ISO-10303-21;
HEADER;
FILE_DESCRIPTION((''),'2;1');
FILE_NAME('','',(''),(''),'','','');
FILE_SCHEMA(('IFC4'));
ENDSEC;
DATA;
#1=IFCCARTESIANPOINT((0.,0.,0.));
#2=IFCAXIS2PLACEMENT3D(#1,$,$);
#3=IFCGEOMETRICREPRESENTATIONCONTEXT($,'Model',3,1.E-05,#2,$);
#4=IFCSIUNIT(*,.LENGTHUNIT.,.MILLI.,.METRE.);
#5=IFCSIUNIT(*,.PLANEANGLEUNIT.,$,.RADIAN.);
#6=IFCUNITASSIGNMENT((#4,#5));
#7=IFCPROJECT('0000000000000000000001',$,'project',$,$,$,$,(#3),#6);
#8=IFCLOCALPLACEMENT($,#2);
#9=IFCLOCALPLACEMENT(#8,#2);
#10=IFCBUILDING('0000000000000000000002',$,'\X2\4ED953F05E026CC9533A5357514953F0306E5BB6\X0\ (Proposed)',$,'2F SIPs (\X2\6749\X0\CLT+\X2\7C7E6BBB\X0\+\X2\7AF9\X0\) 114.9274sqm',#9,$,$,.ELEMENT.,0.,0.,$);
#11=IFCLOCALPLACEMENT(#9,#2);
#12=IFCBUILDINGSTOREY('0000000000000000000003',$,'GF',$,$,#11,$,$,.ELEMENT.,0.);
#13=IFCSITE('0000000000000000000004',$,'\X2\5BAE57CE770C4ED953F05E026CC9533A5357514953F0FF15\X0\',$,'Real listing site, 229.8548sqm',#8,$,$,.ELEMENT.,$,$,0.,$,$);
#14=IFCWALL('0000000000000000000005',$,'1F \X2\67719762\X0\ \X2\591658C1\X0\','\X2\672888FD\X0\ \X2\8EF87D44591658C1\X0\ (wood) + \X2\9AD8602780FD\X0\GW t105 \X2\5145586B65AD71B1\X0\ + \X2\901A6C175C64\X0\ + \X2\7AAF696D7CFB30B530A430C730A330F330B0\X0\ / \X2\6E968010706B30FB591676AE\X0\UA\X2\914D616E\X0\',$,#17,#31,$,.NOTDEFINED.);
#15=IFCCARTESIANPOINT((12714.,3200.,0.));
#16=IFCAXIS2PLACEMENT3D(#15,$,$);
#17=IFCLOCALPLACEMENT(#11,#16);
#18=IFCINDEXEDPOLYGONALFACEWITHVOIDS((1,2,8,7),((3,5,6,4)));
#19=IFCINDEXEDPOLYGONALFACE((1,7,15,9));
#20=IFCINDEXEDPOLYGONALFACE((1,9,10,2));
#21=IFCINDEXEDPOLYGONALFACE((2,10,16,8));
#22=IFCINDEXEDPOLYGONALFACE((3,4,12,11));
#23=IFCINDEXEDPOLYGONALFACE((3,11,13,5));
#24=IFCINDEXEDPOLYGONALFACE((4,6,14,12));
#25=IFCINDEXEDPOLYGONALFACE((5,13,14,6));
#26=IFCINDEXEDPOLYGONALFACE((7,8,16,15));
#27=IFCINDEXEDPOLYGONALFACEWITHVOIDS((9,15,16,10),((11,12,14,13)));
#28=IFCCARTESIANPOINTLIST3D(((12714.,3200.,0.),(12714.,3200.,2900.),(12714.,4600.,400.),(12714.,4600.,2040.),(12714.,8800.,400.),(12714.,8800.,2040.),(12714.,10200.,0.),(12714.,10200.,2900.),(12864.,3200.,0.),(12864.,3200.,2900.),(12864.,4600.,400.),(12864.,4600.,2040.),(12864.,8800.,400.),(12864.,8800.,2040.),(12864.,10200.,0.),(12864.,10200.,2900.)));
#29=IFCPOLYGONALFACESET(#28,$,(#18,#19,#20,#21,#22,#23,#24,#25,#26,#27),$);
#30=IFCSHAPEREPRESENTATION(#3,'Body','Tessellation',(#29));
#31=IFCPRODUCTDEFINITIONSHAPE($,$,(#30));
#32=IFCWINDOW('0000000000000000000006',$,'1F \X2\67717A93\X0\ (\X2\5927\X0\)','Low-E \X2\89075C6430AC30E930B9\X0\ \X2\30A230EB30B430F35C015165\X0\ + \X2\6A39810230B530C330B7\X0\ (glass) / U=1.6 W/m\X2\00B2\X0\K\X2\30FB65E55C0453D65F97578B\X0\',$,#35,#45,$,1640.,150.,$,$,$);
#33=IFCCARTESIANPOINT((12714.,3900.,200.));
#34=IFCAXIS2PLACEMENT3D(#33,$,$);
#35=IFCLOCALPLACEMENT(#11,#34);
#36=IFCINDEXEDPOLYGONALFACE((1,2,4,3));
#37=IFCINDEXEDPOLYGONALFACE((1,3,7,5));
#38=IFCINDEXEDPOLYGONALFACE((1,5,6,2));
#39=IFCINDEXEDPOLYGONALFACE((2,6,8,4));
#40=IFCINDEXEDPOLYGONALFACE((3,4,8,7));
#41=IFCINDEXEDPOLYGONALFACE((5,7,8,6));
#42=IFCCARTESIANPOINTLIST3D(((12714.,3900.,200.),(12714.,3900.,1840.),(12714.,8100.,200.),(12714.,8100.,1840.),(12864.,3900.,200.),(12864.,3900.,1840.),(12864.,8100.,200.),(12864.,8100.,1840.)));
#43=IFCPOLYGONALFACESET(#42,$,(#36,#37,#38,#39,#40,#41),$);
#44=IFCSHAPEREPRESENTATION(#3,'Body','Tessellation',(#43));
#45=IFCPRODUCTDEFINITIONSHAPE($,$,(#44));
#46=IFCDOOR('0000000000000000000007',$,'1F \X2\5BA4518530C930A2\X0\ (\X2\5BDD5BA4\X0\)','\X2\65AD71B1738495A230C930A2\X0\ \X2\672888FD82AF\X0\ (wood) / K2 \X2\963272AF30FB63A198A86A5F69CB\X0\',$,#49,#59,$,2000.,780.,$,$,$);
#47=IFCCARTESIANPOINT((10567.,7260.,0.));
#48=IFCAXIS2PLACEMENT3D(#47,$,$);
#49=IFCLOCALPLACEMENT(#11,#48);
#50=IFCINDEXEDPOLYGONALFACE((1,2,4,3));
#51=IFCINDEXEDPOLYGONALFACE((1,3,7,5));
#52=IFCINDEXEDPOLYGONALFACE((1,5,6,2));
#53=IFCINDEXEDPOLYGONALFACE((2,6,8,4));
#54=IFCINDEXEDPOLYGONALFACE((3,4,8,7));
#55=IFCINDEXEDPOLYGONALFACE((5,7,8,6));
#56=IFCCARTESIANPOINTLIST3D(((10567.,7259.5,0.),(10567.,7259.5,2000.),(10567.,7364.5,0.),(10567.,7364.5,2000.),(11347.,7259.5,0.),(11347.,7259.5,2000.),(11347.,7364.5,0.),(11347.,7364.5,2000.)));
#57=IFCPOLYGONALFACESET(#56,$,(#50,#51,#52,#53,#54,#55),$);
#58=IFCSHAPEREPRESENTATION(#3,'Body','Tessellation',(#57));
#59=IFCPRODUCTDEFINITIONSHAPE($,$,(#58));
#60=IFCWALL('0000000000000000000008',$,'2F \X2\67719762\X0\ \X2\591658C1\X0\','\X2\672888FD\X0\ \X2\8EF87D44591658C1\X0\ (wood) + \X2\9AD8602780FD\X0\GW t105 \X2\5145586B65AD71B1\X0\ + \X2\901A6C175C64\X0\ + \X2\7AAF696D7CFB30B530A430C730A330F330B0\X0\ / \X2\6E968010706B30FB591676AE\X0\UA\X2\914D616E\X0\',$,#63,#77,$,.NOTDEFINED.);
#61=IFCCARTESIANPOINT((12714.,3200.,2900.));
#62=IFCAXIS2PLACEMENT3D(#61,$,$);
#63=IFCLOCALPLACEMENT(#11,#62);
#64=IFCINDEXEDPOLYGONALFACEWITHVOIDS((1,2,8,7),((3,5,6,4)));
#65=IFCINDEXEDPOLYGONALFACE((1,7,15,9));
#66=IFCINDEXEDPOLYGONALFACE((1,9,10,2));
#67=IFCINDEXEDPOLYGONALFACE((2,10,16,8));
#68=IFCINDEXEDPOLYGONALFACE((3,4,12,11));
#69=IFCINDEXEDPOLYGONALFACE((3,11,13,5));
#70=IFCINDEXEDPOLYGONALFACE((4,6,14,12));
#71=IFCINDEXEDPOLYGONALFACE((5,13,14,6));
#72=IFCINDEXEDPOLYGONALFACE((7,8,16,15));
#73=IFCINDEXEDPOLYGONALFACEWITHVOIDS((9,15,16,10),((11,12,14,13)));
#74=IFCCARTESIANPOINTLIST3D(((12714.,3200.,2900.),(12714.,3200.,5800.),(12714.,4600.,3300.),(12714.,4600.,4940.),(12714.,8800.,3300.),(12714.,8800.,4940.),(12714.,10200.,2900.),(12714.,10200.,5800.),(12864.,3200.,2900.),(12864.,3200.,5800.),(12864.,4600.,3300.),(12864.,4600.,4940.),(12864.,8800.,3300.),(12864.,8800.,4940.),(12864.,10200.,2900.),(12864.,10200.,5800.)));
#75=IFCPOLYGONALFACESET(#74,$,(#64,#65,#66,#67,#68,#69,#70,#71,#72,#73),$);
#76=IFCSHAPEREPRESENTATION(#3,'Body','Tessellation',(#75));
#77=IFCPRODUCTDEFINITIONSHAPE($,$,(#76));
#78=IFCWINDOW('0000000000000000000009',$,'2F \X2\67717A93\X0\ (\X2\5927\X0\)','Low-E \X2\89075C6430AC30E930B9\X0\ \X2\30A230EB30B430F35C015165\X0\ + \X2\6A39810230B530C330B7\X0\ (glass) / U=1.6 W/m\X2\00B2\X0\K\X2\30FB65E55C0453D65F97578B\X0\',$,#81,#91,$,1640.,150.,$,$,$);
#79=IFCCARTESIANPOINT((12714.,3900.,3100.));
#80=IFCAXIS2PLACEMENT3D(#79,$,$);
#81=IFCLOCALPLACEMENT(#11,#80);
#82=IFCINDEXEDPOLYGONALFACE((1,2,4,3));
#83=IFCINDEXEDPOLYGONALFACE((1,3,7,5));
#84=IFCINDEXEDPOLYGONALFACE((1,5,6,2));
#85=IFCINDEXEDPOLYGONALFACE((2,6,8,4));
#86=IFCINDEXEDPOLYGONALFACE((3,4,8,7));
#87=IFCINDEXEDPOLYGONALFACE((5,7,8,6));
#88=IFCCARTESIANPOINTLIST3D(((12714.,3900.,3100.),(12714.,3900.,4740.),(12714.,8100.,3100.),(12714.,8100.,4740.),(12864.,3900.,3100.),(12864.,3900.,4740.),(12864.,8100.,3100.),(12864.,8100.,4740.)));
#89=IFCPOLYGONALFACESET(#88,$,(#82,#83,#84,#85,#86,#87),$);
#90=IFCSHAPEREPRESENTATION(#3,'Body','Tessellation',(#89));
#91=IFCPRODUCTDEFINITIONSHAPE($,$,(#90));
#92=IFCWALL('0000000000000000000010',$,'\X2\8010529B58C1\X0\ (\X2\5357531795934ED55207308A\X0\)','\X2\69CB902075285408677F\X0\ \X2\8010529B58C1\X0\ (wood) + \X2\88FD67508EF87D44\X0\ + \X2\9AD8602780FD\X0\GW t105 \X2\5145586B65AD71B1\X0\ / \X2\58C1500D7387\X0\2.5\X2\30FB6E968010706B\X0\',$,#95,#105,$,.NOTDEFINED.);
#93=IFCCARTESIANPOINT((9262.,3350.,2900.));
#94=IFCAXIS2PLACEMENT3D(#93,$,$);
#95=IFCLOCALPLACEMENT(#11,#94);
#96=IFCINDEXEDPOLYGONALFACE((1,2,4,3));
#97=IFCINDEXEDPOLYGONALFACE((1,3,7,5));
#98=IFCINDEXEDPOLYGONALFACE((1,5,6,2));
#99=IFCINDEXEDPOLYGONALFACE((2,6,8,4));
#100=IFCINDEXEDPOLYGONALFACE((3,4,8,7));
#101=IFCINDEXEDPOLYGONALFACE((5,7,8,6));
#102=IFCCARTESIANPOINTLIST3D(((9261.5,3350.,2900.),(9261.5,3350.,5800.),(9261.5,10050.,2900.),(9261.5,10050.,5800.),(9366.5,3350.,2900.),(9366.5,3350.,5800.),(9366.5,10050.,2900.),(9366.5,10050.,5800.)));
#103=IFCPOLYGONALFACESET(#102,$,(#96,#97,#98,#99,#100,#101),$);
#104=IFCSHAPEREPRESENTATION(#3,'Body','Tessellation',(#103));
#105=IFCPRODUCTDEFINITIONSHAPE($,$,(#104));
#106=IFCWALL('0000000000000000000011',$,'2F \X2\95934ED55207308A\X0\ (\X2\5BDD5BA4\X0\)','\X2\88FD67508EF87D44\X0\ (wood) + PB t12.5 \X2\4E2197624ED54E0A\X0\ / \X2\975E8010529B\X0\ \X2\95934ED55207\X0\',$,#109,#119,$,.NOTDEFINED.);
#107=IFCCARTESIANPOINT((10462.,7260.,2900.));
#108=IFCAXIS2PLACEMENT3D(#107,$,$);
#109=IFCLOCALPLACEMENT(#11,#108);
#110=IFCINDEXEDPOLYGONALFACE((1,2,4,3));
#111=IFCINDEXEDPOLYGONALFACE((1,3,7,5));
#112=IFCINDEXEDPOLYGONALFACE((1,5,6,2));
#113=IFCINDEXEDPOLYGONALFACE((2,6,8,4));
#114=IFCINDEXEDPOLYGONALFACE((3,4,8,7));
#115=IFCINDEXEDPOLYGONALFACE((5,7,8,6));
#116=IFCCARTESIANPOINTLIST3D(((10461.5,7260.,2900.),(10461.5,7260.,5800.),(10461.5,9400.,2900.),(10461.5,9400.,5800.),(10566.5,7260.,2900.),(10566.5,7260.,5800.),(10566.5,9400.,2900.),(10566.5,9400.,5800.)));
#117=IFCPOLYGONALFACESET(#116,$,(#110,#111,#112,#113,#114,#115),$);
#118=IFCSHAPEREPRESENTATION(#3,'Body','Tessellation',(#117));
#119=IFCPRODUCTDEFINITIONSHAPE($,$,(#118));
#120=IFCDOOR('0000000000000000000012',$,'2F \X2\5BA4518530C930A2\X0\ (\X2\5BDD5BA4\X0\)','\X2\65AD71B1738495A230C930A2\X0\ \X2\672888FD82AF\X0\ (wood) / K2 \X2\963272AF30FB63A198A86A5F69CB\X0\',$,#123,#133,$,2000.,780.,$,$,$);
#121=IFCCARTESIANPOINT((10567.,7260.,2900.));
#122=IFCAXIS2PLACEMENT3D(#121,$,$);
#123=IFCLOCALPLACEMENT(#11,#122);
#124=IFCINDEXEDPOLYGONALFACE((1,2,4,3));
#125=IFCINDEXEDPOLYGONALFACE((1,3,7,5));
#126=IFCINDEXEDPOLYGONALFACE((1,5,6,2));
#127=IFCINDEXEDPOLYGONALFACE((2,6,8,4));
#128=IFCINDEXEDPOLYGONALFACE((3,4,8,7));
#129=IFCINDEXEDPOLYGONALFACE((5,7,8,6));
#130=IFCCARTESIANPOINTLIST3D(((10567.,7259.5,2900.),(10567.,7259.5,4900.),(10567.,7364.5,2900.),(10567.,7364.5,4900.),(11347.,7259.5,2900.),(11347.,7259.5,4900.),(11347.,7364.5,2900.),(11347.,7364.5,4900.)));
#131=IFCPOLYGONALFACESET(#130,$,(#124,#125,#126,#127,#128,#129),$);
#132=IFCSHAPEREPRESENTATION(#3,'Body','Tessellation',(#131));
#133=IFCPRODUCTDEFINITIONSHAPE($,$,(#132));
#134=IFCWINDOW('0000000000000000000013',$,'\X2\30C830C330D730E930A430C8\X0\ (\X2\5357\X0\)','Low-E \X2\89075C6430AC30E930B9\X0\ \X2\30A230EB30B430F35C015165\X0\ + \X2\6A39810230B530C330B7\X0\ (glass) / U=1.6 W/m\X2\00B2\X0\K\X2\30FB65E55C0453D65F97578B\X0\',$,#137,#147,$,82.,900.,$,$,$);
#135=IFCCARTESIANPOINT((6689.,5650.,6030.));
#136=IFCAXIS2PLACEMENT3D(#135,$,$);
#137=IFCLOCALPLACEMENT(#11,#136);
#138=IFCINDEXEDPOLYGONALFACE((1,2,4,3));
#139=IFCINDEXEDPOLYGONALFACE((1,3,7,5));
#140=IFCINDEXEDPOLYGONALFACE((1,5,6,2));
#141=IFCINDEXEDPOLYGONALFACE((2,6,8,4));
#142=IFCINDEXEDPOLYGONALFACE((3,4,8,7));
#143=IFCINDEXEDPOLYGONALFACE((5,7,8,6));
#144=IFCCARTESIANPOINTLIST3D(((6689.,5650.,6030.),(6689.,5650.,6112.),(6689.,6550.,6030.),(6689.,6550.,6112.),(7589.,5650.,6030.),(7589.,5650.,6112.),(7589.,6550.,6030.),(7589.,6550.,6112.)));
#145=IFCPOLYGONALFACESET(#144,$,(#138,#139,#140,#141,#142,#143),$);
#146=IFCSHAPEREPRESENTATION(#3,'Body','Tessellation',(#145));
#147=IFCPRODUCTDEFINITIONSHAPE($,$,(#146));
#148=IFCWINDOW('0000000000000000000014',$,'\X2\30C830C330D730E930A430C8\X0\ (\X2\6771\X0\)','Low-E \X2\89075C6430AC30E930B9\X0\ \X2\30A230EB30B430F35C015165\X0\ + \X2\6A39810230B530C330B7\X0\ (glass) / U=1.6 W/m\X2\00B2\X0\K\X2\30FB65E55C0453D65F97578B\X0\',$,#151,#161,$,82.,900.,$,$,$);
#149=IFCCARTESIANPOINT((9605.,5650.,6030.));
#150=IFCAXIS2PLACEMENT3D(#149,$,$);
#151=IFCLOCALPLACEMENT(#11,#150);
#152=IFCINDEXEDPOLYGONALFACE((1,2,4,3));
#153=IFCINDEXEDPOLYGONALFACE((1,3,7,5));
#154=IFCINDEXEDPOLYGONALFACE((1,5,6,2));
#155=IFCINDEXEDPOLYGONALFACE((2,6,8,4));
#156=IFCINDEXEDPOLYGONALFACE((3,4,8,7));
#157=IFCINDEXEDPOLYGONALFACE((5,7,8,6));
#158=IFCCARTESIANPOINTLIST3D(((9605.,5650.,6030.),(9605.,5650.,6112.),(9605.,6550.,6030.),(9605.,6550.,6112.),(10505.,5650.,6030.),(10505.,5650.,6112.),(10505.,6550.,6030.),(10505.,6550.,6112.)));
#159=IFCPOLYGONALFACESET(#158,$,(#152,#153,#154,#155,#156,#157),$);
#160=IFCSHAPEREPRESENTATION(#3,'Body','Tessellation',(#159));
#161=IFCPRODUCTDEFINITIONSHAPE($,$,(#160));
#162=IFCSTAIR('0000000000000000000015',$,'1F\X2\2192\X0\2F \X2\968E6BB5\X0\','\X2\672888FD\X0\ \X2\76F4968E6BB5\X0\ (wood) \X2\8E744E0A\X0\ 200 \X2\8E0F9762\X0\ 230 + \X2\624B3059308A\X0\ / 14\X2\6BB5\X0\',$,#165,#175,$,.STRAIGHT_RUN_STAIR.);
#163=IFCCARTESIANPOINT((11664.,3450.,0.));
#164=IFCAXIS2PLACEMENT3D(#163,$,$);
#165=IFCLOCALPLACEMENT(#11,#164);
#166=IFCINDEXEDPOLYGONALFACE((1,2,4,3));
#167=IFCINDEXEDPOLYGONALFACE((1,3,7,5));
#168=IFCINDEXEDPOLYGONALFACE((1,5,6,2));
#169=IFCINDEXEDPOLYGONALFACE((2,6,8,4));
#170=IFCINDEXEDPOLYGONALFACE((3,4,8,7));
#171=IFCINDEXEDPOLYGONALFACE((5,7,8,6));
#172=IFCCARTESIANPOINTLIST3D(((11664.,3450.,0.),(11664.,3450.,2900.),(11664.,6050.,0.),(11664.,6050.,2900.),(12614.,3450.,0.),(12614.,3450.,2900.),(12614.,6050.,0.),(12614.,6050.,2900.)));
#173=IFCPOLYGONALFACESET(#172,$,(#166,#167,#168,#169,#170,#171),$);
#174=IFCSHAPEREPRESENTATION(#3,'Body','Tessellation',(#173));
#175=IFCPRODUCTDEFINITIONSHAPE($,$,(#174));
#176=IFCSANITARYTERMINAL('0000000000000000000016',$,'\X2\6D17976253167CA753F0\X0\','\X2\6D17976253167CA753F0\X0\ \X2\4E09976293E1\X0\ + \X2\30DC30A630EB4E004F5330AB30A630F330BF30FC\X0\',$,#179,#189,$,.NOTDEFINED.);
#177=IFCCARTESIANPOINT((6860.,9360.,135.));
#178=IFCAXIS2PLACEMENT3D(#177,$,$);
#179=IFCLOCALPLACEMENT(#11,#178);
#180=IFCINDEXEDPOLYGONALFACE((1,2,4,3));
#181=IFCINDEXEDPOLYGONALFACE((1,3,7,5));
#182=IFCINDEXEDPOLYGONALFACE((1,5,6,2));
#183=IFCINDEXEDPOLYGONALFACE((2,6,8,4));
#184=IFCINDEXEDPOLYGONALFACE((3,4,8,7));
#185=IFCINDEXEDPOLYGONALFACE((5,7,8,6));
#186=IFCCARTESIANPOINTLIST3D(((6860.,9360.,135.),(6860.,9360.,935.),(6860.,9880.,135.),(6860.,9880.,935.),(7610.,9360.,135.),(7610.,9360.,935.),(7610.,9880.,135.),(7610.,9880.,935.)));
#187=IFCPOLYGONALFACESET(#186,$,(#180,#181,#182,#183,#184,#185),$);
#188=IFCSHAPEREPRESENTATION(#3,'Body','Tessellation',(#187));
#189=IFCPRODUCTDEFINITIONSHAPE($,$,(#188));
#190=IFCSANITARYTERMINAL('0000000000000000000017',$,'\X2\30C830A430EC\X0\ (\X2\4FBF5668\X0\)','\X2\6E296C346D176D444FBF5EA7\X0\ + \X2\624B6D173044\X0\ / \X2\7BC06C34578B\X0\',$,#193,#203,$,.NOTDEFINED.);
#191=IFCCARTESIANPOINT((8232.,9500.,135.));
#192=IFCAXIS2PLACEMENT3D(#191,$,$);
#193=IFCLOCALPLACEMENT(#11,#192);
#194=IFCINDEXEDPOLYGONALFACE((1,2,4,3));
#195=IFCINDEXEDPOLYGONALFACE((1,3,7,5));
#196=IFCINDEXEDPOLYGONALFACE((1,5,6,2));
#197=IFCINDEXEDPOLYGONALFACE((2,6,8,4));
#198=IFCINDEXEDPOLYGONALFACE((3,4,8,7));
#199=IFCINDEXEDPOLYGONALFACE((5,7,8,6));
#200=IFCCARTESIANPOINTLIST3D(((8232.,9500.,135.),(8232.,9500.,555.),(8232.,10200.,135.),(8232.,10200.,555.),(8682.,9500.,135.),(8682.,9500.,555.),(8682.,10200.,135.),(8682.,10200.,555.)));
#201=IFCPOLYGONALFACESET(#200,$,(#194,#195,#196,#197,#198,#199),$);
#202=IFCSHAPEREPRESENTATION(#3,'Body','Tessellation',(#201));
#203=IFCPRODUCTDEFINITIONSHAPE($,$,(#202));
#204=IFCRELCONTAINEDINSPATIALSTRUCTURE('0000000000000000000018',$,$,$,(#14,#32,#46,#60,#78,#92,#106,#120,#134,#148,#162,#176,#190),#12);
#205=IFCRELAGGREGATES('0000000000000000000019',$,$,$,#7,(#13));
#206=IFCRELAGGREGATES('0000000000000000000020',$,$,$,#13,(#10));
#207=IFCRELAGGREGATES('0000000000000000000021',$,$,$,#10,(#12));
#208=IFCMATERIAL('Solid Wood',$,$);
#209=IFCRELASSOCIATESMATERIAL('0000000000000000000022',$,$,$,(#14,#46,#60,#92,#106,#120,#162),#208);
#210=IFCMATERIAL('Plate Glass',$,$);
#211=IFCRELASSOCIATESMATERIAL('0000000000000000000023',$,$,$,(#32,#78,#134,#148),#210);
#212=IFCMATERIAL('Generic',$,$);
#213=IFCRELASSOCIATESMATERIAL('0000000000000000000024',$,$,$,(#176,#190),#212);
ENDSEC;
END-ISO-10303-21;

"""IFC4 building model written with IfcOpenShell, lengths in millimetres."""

from ifc_helpers import new_model, si_unit, frame, frame_2d, origin, place, context, project, spatial, rectangle, extrude, material, element, fill, save


model = new_model("IFC4")

# Units and contexts
model_context = context("Model", 3, precision=1e-05, world=origin())
ifc_project = project(units=[si_unit("LENGTHUNIT", "METRE", prefix="MILLI"), si_unit("PLANEANGLEUNIT", "RADIAN")], contexts=[model_context])

# Site, building, storey
site_placement = place(None, origin())
site = spatial("IfcSite", under=ifc_project, at=site_placement, Name="宮城県仙台市泉区南光台５", ObjectType="Real listing site, 229.8548sqm", CompositionType="ELEMENT", RefElevation=0.0)
building_placement = place(site_placement, origin())
building = spatial("IfcBuilding", under=site, at=building_placement, Name="仙台市泉区南光台の家 (Proposed)", ObjectType="2F SIPs (杉CLT+籾殻+竹) 114.9274sqm", CompositionType="ELEMENT", ElevationOfRefHeight=0.0, ElevationOfTerrain=0.0)
storey_placement = place(building_placement, origin())
storey = spatial("IfcBuildingStorey", under=building, at=storey_placement, Name="GF", CompositionType="ELEMENT", Elevation=0.0)

# Wall, opening, window
ifc_material_1 = material(Name="Solid Wood")
wall_1_placement = place(storey_placement, frame((12714.0, 3200.0, 0.0)))
wall_1 = element("IfcWall", 1, at=wall_1_placement, inside=storey, material=ifc_material_1, Name="1F 東面 外壁", Description="木製 軸組外壁 (wood) + 高性能GW t105 充填断熱 + 通気層 + 窯業系サイディング / 準耐火・外皮UA配慮", PredefinedType="NOTDEFINED", context=model_context, shape_type="SweptSolid", body=[
    extrude(rectangle(XDim=150.0, YDim=7000.0, at=frame_2d((75.0, 3500.0))), frame((12714.0, 3200.0, 0.0)), (0.0, 0.0, 1.0), 2900.0),
])
opening_1_placement = place(storey_placement, frame((12714.0, 3900.0, 200.0)))
opening_1 = element("IfcOpeningElement", 2, at=opening_1_placement, cuts=wall_1, PredefinedType="NOTDEFINED", context=model_context, shape_type="SweptSolid", body=[
    extrude(rectangle(XDim=150.0, YDim=4200.0, at=frame_2d((75.0, 2100.0))), frame((12714.0, 3900.0, 200.0)), (0.0, 0.0, 1.0), 1640.0),
])
ifc_material_2 = material(Name="Plate Glass")
window_1_placement = place(storey_placement, frame((12714.0, 3900.0, 200.0)))
window_1 = element("IfcWindow", 3, at=window_1_placement, inside=storey, material=ifc_material_2, Name="1F 東窓 (大)", Description="Low-E 複層ガラス アルゴン封入 + 樹脂サッシ (glass) / U=1.6 W/m²K・日射取得型", OverallHeight=1640.0, OverallWidth=150.0, context=model_context, shape_type="SweptSolid", body=[
    extrude(rectangle(XDim=150.0, YDim=4200.0, at=frame_2d((75.0, 2100.0))), frame((12714.0, 3900.0, 200.0)), (0.0, 0.0, 1.0), 1640.0),
])
fill(opening_1, window_1)

# Door
door_1_placement = place(storey_placement, frame((10567.0, 7260.0, 0.0)))
element("IfcDoor", 4, at=door_1_placement, inside=storey, material=ifc_material_1, Name="1F 室内ドア (寝室)", Description="断熱玄関ドア 木製芯 (wood) / K2 防犯・採風機構", OverallHeight=2000.0, OverallWidth=780.0, context=model_context, shape_type="SweptSolid", body=[
    extrude(rectangle(XDim=780.0, YDim=105.0, at=frame_2d((390.0, 52.0))), frame((10567.0, 7260.0, 0.0)), (0.0, 0.0, 1.0), 2000.0),
])

# Wall, opening, window
wall_2_placement = place(storey_placement, frame((12714.0, 3200.0, 2900.0)))
wall_2 = element("IfcWall", 5, at=wall_2_placement, inside=storey, material=ifc_material_1, Name="2F 東面 外壁", Description="木製 軸組外壁 (wood) + 高性能GW t105 充填断熱 + 通気層 + 窯業系サイディング / 準耐火・外皮UA配慮", PredefinedType="NOTDEFINED", context=model_context, shape_type="SweptSolid", body=[
    extrude(rectangle(XDim=150.0, YDim=7000.0, at=frame_2d((75.0, 3500.0))), frame((12714.0, 3200.0, 2900.0)), (0.0, 0.0, 1.0), 2900.0),
])
opening_2_placement = place(storey_placement, frame((12714.0, 3900.0, 3100.0)))
opening_2 = element("IfcOpeningElement", 6, at=opening_2_placement, cuts=wall_2, PredefinedType="NOTDEFINED", context=model_context, shape_type="SweptSolid", body=[
    extrude(rectangle(XDim=150.0, YDim=4200.0, at=frame_2d((75.0, 2100.0))), frame((12714.0, 3900.0, 3100.0)), (0.0, 0.0, 1.0), 1640.0),
])
window_2_placement = place(storey_placement, frame((12714.0, 3900.0, 3100.0)))
window_2 = element("IfcWindow", 7, at=window_2_placement, inside=storey, material=ifc_material_2, Name="2F 東窓 (大)", Description="Low-E 複層ガラス アルゴン封入 + 樹脂サッシ (glass) / U=1.6 W/m²K・日射取得型", OverallHeight=1640.0, OverallWidth=150.0, context=model_context, shape_type="SweptSolid", body=[
    extrude(rectangle(XDim=150.0, YDim=4200.0, at=frame_2d((75.0, 2100.0))), frame((12714.0, 3900.0, 3100.0)), (0.0, 0.0, 1.0), 1640.0),
])
fill(opening_2, window_2)

# Walls
wall_3_placement = place(storey_placement, frame((9262.0, 3350.0, 2900.0)))
element("IfcWall", 8, at=wall_3_placement, inside=storey, material=ifc_material_1, Name="耐力壁 (南北間仕切り)", Description="構造用合板 耐力壁 (wood) + 製材軸組 + 高性能GW t105 充填断熱 / 壁倍率2.5・準耐火", PredefinedType="NOTDEFINED", context=model_context, shape_type="SweptSolid", body=[
    extrude(rectangle(XDim=105.0, YDim=6700.0, at=frame_2d((52.0, 3350.0))), frame((9262.0, 3350.0, 2900.0)), (0.0, 0.0, 1.0), 2900.0),
])
wall_4_placement = place(storey_placement, frame((10462.0, 7260.0, 2900.0)))
element("IfcWall", 9, at=wall_4_placement, inside=storey, material=ifc_material_1, Name="2F 間仕切り (寝室)", Description="製材軸組 (wood) + PB t12.5 両面仕上 / 非耐力 間仕切", PredefinedType="NOTDEFINED", context=model_context, shape_type="SweptSolid", body=[
    extrude(rectangle(XDim=105.0, YDim=2140.0, at=frame_2d((52.0, 1070.0))), frame((10462.0, 7260.0, 2900.0)), (0.0, 0.0, 1.0), 2900.0),
])

# Door
door_2_placement = place(storey_placement, frame((10567.0, 7260.0, 2900.0)))
element("IfcDoor", 10, at=door_2_placement, inside=storey, material=ifc_material_1, Name="2F 室内ドア (寝室)", Description="断熱玄関ドア 木製芯 (wood) / K2 防犯・採風機構", OverallHeight=2000.0, OverallWidth=780.0, context=model_context, shape_type="SweptSolid", body=[
    extrude(rectangle(XDim=780.0, YDim=105.0, at=frame_2d((390.0, 52.0))), frame((10567.0, 7260.0, 2900.0)), (0.0, 0.0, 1.0), 2000.0),
])

# Windows
window_3_placement = place(storey_placement, frame((6689.0, 5650.0, 6030.0)))
element("IfcWindow", 11, at=window_3_placement, inside=storey, material=ifc_material_2, Name="トップライト (南)", Description="Low-E 複層ガラス アルゴン封入 + 樹脂サッシ (glass) / U=1.6 W/m²K・日射取得型", OverallHeight=82.0, OverallWidth=900.0, context=model_context, shape_type="SweptSolid", body=[
    extrude(rectangle(XDim=900.0, YDim=900.0, at=frame_2d((450.0, 450.0))), frame((6689.0, 5650.0, 6030.0)), (0.0, 0.0, 1.0), 82.0),
])
window_4_placement = place(storey_placement, frame((9605.0, 5650.0, 6030.0)))
element("IfcWindow", 12, at=window_4_placement, inside=storey, material=ifc_material_2, Name="トップライト (東)", Description="Low-E 複層ガラス アルゴン封入 + 樹脂サッシ (glass) / U=1.6 W/m²K・日射取得型", OverallHeight=82.0, OverallWidth=900.0, context=model_context, shape_type="SweptSolid", body=[
    extrude(rectangle(XDim=900.0, YDim=900.0, at=frame_2d((450.0, 450.0))), frame((9605.0, 5650.0, 6030.0)), (0.0, 0.0, 1.0), 82.0),
])

# Stair
stair_placement = place(storey_placement, frame((11664.0, 3450.0, 0.0)))
element("IfcStair", 13, at=stair_placement, inside=storey, material=ifc_material_1, Name="1F→2F 階段", Description="木製 直階段 (wood) 蹴上 200 踏面 230 + 手すり / 14段", PredefinedType="STRAIGHT_RUN_STAIR", context=model_context, shape_type="SweptSolid", body=[
    extrude(rectangle(XDim=950.0, YDim=2600.0, at=frame_2d((475.0, 1300.0))), frame((11664.0, 3450.0, 0.0)), (0.0, 0.0, 1.0), 2900.0),
])

# Sanitary terminals
ifc_material_3 = material(Name="Generic")
sanitary_terminal_1_placement = place(storey_placement, frame((6860.0, 9360.0, 135.0)))
element("IfcSanitaryTerminal", 14, at=sanitary_terminal_1_placement, inside=storey, material=ifc_material_3, Name="洗面化粧台", Description="洗面化粧台 三面鏡 + ボウル一体カウンター", PredefinedType="NOTDEFINED", context=model_context, shape_type="SweptSolid", body=[
    extrude(rectangle(XDim=750.0, YDim=520.0, at=frame_2d((375.0, 260.0))), frame((6860.0, 9360.0, 135.0)), (0.0, 0.0, 1.0), 800.0),
])
sanitary_terminal_2_placement = place(storey_placement, frame((8232.0, 9500.0, 135.0)))
element("IfcSanitaryTerminal", 15, at=sanitary_terminal_2_placement, inside=storey, material=ifc_material_3, Name="トイレ (便器)", Description="温水洗浄便座 + 手洗い / 節水型", PredefinedType="NOTDEFINED", context=model_context, shape_type="SweptSolid", body=[
    extrude(rectangle(XDim=450.0, YDim=700.0, at=frame_2d((225.0, 350.0))), frame((8232.0, 9500.0, 135.0)), (0.0, 0.0, 1.0), 420.0),
])

save(model, "model.ifc")
